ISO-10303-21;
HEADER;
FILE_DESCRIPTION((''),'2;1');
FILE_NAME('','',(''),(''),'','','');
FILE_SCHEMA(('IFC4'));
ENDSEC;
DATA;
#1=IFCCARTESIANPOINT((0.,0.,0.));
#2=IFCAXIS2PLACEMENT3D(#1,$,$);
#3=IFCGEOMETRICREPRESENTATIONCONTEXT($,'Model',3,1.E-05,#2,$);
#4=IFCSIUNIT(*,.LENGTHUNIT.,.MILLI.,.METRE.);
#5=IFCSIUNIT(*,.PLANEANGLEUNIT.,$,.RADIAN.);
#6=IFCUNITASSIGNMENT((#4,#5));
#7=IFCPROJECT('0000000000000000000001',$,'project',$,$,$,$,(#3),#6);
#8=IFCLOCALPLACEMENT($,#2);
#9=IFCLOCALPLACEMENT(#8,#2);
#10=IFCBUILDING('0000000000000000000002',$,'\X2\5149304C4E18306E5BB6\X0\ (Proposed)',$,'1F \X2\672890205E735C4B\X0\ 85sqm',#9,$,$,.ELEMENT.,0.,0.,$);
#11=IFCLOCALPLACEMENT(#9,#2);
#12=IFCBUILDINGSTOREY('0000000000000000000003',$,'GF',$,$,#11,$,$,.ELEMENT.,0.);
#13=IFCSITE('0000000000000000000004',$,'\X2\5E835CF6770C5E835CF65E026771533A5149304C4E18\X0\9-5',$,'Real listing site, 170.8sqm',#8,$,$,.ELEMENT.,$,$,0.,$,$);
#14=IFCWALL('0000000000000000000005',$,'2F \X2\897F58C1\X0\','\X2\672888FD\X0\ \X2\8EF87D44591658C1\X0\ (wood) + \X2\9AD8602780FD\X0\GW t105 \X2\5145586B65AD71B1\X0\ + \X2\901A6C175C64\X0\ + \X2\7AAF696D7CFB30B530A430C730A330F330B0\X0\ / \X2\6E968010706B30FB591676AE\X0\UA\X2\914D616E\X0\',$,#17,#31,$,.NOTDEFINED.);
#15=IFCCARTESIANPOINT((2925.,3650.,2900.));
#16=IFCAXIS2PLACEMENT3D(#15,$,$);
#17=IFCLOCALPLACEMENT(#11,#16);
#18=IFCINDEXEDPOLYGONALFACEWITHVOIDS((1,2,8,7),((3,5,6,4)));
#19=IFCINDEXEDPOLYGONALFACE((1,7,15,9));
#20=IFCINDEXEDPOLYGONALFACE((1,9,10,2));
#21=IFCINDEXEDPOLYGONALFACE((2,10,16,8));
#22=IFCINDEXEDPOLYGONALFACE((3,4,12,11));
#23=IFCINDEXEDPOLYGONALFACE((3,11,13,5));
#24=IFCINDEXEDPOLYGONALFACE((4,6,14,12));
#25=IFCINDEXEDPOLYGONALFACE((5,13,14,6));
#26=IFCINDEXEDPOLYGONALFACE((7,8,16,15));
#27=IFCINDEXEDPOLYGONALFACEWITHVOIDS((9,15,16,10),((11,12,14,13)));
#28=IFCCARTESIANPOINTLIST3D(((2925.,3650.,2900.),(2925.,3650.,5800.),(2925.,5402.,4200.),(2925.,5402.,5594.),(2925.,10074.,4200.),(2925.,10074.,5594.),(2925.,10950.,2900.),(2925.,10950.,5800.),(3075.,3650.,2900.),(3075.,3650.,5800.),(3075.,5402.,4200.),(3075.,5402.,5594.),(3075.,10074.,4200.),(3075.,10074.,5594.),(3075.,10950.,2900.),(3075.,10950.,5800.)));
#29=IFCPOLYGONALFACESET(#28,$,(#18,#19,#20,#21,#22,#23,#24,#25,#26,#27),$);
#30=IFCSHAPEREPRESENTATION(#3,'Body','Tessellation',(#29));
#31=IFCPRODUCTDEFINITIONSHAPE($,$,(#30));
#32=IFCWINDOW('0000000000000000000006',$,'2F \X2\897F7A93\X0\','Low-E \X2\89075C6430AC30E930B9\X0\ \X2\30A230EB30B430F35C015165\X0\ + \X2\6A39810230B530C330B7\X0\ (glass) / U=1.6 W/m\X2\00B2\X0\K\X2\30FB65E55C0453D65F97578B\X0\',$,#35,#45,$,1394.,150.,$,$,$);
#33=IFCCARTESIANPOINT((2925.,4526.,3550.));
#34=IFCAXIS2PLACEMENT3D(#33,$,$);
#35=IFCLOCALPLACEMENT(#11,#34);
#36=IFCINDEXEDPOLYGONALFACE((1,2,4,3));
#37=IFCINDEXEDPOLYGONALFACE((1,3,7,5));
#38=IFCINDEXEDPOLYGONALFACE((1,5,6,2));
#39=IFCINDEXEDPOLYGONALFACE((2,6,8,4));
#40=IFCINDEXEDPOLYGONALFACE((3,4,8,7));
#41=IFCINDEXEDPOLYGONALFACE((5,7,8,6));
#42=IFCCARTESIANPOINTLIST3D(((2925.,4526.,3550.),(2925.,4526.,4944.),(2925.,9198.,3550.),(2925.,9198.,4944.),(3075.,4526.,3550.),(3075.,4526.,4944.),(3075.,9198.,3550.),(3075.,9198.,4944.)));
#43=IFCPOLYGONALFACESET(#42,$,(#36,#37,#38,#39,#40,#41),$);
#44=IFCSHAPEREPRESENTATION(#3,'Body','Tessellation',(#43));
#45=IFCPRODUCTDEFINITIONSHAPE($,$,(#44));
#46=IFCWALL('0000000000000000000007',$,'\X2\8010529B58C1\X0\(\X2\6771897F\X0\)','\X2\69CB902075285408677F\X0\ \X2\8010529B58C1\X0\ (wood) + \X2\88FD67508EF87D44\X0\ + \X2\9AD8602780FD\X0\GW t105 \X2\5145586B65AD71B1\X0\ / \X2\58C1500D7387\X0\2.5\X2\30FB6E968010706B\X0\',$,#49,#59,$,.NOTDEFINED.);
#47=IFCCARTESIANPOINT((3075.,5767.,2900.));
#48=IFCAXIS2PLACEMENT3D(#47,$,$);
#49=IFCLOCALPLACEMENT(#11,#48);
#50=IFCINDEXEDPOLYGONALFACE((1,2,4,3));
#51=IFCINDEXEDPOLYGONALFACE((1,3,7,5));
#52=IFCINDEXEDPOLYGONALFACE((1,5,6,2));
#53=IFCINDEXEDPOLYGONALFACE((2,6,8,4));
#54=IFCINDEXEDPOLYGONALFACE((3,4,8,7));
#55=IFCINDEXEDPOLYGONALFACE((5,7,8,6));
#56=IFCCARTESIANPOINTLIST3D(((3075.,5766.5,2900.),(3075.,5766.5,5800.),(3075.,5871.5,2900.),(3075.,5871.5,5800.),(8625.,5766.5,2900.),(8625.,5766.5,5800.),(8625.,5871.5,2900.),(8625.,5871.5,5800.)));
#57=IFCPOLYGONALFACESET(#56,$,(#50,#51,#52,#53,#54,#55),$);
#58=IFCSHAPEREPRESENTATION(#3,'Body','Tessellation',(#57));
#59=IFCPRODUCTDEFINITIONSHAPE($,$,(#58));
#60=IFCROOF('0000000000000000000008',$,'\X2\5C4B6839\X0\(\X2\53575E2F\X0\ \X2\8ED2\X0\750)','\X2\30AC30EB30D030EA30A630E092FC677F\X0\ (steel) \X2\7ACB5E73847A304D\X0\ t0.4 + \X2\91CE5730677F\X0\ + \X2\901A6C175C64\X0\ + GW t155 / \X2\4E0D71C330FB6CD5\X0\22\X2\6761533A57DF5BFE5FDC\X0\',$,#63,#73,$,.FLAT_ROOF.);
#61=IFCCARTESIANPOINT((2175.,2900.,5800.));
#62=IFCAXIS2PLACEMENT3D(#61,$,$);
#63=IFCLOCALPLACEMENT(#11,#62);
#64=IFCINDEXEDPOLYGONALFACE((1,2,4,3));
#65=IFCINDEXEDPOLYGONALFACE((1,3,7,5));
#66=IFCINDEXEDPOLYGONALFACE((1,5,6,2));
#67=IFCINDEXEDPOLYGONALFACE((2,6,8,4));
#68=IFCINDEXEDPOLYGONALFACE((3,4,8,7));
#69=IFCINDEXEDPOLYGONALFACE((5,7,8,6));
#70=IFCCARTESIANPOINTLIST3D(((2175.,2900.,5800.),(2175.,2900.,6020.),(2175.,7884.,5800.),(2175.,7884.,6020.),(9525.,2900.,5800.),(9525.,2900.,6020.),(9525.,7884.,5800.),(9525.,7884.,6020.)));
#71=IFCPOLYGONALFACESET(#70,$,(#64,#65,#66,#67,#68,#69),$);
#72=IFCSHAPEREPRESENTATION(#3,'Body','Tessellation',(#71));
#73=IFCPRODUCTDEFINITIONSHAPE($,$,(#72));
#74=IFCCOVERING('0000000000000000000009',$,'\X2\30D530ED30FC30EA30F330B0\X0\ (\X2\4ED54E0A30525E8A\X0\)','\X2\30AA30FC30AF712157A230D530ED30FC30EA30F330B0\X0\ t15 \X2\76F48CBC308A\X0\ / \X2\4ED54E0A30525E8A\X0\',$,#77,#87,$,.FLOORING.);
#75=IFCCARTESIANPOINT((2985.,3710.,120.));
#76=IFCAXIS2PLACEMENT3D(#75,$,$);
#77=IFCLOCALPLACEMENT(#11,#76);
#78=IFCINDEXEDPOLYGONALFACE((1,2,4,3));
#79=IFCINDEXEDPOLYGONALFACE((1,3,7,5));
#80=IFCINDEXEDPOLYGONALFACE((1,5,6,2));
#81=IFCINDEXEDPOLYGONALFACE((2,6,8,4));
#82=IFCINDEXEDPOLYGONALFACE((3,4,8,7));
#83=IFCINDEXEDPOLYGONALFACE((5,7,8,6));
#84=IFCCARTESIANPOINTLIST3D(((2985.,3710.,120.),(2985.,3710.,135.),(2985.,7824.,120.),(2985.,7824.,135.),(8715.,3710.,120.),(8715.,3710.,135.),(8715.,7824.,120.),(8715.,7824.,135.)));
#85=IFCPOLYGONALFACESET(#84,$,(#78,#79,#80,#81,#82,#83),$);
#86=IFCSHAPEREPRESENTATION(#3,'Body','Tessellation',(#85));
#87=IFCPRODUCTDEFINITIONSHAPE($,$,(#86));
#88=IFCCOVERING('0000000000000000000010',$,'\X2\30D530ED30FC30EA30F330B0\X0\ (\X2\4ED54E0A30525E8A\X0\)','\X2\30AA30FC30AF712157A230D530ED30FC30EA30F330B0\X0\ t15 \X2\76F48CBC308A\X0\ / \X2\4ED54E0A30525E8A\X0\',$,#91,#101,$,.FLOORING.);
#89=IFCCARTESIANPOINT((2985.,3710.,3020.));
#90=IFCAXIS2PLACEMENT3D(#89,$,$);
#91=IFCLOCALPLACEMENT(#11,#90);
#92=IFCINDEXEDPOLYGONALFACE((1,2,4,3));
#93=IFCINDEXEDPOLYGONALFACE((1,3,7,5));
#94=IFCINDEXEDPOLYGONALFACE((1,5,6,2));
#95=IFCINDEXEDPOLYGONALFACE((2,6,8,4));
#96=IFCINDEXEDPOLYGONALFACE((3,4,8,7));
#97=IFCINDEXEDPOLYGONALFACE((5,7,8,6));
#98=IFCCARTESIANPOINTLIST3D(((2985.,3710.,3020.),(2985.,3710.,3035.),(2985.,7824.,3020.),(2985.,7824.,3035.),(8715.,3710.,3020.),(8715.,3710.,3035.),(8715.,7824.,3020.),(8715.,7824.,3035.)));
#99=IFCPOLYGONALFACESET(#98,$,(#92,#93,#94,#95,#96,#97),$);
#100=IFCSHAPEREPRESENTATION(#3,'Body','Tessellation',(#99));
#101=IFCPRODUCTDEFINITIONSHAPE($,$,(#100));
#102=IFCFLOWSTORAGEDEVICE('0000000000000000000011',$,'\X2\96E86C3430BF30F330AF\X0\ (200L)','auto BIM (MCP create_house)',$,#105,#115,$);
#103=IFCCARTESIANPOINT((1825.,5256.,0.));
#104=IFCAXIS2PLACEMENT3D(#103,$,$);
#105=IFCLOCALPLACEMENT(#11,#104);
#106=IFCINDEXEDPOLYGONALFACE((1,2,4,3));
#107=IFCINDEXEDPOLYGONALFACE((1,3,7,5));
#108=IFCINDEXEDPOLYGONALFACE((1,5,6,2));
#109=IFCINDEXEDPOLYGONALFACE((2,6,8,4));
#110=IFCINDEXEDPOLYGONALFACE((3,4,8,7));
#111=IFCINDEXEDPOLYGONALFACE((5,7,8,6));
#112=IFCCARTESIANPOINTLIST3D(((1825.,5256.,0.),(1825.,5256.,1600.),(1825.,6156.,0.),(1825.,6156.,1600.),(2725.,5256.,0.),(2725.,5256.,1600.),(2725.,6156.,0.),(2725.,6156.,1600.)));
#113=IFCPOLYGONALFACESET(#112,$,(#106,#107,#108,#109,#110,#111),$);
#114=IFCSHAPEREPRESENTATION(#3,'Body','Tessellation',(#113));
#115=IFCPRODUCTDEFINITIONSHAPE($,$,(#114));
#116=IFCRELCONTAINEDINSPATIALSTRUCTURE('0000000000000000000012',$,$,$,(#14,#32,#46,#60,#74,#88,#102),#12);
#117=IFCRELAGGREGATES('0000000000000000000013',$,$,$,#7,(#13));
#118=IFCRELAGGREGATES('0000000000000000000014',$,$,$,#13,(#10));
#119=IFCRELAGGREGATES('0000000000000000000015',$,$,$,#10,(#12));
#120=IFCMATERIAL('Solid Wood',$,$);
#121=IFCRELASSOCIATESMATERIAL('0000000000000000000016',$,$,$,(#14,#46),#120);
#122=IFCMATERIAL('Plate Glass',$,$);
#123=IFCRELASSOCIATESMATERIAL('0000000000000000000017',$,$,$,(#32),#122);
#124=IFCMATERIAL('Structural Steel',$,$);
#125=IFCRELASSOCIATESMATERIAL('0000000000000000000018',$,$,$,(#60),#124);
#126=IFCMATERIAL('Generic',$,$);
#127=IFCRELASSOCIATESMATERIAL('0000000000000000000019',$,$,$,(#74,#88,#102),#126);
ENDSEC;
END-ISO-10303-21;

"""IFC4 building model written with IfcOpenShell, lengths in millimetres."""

from ifc_helpers import new_model, si_unit, frame, frame_2d, origin, place, context, project, spatial, rectangle, extrude, material, element, fill, save


model = new_model("IFC4")

# Units and contexts
model_context = context("Model", 3, precision=1e-05, world=origin())
ifc_project = project(units=[si_unit("LENGTHUNIT", "METRE", prefix="MILLI"), si_unit("PLANEANGLEUNIT", "RADIAN")], contexts=[model_context])

# Site, building, storey
site_placement = place(None, origin())
site = spatial("IfcSite", under=ifc_project, at=site_placement, Name="広島県広島市東区光が丘9-5", ObjectType="Real listing site, 170.8sqm", CompositionType="ELEMENT", RefElevation=0.0)
building_placement = place(site_placement, origin())
building = spatial("IfcBuilding", under=site, at=building_placement, Name="光が丘の家 (Proposed)", ObjectType="1F 木造平屋 85sqm", CompositionType="ELEMENT", ElevationOfRefHeight=0.0, ElevationOfTerrain=0.0)
storey_placement = place(building_placement, origin())
storey = spatial("IfcBuildingStorey", under=building, at=storey_placement, Name="GF", CompositionType="ELEMENT", Elevation=0.0)

# Shared definitions
ifc_material_1 = material(Name="Solid Wood")
ifc_material_2 = material(Name="Generic")

# Shared definitions
ifc_material_3 = material(Name="Plate Glass")

# Wall, opening, window
wall_1_placement = place(storey_placement, frame((2925.0, 3650.0, 2900.0)))
wall_1 = element("IfcWall", 1, at=wall_1_placement, inside=storey, material=ifc_material_1, Name="2F 西壁", Description="木製 軸組外壁 (wood) + 高性能GW t105 充填断熱 + 通気層 + 窯業系サイディング / 準耐火・外皮UA配慮", PredefinedType="NOTDEFINED", context=model_context, shape_type="SweptSolid", body=[
    extrude(rectangle(XDim=150.0, YDim=7300.0, at=frame_2d((75.0, 3650.0))), frame((2925.0, 3650.0, 2900.0)), (0.0, 0.0, 1.0), 2900.0),
])
opening_1_placement = place(storey_placement, frame((2925.0, 4526.0, 3550.0)))
opening_1 = element("IfcOpeningElement", 2, at=opening_1_placement, cuts=wall_1, PredefinedType="NOTDEFINED", context=model_context, shape_type="SweptSolid", body=[
    extrude(rectangle(XDim=150.0, YDim=4672.0, at=frame_2d((75.0, 2336.0))), frame((2925.0, 4526.0, 3550.0)), (0.0, 0.0, 1.0), 1394.0),
])
window_1_placement = place(storey_placement, frame((2925.0, 4526.0, 3550.0)))
window_1 = element("IfcWindow", 3, at=window_1_placement, inside=storey, material=ifc_material_3, Name="2F 西窓", Description="Low-E 複層ガラス アルゴン封入 + 樹脂サッシ (glass) / U=1.6 W/m²K・日射取得型", OverallHeight=1394.0, OverallWidth=150.0, context=model_context, shape_type="SweptSolid", body=[
    extrude(rectangle(XDim=150.0, YDim=4672.0, at=frame_2d((75.0, 2336.0))), frame((2925.0, 4526.0, 3550.0)), (0.0, 0.0, 1.0), 1394.0),
])
fill(opening_1, window_1)

# Wall
wall_2_placement = place(storey_placement, frame((3075.0, 5767.0, 2900.0)))
element("IfcWall", 4, at=wall_2_placement, inside=storey, material=ifc_material_1, Name="耐力壁(東西)", Description="構造用合板 耐力壁 (wood) + 製材軸組 + 高性能GW t105 充填断熱 / 壁倍率2.5・準耐火", PredefinedType="NOTDEFINED", context=model_context, shape_type="SweptSolid", body=[
    extrude(rectangle(XDim=5550.0, YDim=105.0, at=frame_2d((2775.0, 52.0))), frame((3075.0, 5767.0, 2900.0)), (0.0, 0.0, 1.0), 2900.0),
])

# Roof
ifc_material_4 = material(Name="Structural Steel")
for number, where, name in (
    (5, (2175.0, 2900.0, 5800.0), "屋根(南帯 軒750)"),
):
    element("IfcRoof", number, at=place(storey_placement, frame(where)), inside=storey, material=ifc_material_4, Name=name, Description="ガルバリウム鋼板 (steel) 立平葺き t0.4 + 野地板 + 通気層 + GW t155 / 不燃・法22条区域対応", PredefinedType="FLAT_ROOF", context=model_context, shape_type="SweptSolid", body=[
        extrude(rectangle(XDim=7350.0, YDim=4984.0, at=frame_2d((3675.0, 2492.0))), frame((2175.0, 2900.0, 5800.0)), (0.0, 0.0, 1.0), 220.0),
    ])

# Coverings
covering_1_placement = place(storey_placement, frame((2985.0, 3710.0, 120.0)))
element("IfcCovering", 6, at=covering_1_placement, inside=storey, material=ifc_material_2, Name="フローリング (仕上げ床)", Description="オーク無垢フローリング t15 直貼り / 仕上げ床", PredefinedType="FLOORING", context=model_context, shape_type="SweptSolid", body=[
    extrude(rectangle(XDim=5730.0, YDim=4114.0, at=frame_2d((2865.0, 2057.0))), frame((2985.0, 3710.0, 120.0)), (0.0, 0.0, 1.0), 15.0),
])
covering_2_placement = place(storey_placement, frame((2985.0, 3710.0, 3020.0)))
element("IfcCovering", 7, at=covering_2_placement, inside=storey, material=ifc_material_2, Name="フローリング (仕上げ床)", Description="オーク無垢フローリング t15 直貼り / 仕上げ床", PredefinedType="FLOORING", context=model_context, shape_type="SweptSolid", body=[
    extrude(rectangle(XDim=5730.0, YDim=4114.0, at=frame_2d((2865.0, 2057.0))), frame((2985.0, 3710.0, 3020.0)), (0.0, 0.0, 1.0), 15.0),
])

# Flow storage device
flow_storage_device_placement = place(storey_placement, frame((1825.0, 5256.0, 0.0)))
element("IfcFlowStorageDevice", 8, at=flow_storage_device_placement, inside=storey, material=ifc_material_2, Name="雨水タンク (200L)", Description="auto BIM (MCP create_house)", context=model_context, shape_type="SweptSolid", body=[
    extrude(rectangle(XDim=900.0, YDim=900.0, at=frame_2d((450.0, 450.0))), frame((1825.0, 5256.0, 0.0)), (0.0, 0.0, 1.0), 1600.0),
])

save(model, "model.ifc")
